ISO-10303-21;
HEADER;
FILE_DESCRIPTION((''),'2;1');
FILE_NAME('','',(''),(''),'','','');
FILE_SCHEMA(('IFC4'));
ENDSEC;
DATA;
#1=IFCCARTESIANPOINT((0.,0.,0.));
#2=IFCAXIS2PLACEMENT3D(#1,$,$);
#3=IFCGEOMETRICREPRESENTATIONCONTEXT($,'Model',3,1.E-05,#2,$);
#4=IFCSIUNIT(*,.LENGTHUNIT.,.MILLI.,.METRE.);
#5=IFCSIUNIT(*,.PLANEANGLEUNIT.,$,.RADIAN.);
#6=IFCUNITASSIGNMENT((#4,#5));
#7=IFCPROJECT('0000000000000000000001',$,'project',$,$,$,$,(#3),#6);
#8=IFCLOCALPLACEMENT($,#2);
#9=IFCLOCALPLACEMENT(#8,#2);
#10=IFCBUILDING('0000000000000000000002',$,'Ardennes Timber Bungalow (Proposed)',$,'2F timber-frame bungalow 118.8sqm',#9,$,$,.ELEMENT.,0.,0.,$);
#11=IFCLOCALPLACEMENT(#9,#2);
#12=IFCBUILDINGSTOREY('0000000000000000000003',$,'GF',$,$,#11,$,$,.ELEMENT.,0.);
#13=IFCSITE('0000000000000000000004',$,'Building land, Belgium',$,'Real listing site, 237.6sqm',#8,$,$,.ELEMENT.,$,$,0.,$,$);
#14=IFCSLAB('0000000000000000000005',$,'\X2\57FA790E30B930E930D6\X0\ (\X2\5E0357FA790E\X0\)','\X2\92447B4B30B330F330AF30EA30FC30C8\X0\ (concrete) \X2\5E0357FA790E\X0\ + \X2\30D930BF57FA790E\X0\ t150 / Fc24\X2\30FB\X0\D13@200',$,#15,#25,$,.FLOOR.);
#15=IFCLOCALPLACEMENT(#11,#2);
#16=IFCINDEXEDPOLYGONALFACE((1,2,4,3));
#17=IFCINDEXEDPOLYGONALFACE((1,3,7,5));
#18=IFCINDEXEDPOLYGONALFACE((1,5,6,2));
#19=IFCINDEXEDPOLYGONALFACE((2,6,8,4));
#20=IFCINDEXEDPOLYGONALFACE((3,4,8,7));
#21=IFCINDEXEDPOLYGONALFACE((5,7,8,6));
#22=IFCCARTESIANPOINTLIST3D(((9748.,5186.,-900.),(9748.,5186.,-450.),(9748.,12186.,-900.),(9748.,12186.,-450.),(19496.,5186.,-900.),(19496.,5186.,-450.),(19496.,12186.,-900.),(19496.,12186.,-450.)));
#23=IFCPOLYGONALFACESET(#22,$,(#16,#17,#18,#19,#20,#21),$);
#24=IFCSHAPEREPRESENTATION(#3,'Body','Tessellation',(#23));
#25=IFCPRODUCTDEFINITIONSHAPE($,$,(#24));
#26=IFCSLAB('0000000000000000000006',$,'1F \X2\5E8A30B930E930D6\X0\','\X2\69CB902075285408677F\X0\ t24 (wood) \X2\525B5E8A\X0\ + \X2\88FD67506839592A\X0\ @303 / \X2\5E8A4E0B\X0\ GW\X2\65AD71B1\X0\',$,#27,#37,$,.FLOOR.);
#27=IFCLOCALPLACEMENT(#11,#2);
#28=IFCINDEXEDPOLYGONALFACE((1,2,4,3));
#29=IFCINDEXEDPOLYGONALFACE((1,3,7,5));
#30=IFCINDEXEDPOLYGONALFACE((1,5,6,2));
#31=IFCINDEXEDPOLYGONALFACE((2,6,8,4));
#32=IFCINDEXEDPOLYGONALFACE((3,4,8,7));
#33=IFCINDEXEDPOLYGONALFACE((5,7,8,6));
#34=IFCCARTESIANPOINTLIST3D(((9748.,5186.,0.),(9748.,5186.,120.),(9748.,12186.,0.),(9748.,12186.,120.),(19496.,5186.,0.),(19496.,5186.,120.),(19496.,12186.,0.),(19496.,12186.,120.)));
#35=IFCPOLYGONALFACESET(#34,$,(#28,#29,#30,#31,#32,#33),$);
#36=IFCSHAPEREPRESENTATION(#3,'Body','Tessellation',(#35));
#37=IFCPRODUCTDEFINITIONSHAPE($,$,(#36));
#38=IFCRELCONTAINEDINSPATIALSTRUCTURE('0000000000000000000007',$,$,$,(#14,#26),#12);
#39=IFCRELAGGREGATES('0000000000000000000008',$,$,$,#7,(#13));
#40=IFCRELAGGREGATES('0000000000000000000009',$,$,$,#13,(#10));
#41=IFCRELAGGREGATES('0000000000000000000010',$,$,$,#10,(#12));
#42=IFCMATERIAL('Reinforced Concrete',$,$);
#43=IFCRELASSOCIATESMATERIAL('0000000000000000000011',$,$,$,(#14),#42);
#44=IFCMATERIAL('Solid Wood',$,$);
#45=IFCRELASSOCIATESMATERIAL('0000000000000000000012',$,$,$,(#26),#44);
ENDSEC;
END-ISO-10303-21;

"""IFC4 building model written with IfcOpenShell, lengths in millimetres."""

from ifc_helpers import new_model, si_unit, frame, frame_2d, origin, place, context, project, spatial, rectangle, extrude, material, element, save


model = new_model("IFC4")

# Units and contexts
model_context = context("Model", 3, precision=1e-05, world=origin())
ifc_project = project(units=[si_unit("LENGTHUNIT", "METRE", prefix="MILLI"), si_unit("PLANEANGLEUNIT", "RADIAN")], contexts=[model_context])

# Site, building, storey
site_placement = place(None, origin())
site = spatial("IfcSite", under=ifc_project, at=site_placement, Name="Building land, Belgium", ObjectType="Real listing site, 237.6sqm", CompositionType="ELEMENT", RefElevation=0.0)
building_placement = place(site_placement, origin())
building = spatial("IfcBuilding", under=site, at=building_placement, Name="Ardennes Timber Bungalow (Proposed)", ObjectType="2F timber-frame bungalow 118.8sqm", CompositionType="ELEMENT", ElevationOfRefHeight=0.0, ElevationOfTerrain=0.0)
storey_placement = place(building_placement, origin())
storey = spatial("IfcBuildingStorey", under=building, at=storey_placement, Name="GF", CompositionType="ELEMENT", Elevation=0.0)

# Slabs
ifc_material_1 = material(Name="Reinforced Concrete")
slab_1_placement = place(storey_placement, frame((4874.0, 2593.0, -450.0)))
element("IfcSlab", 1, at=slab_1_placement, inside=storey, material=ifc_material_1, Name="基礎スラブ (布基礎)", Description="鉄筋コンクリート (concrete) 布基礎 + ベタ基礎 t150 / Fc24・D13@200", PredefinedType="FLOOR", context=model_context, shape_type="SweptSolid", body=[
    extrude(rectangle(XDim=9748.0, YDim=7000.0, at=frame_2d((4874.0, 3500.0))), frame((4874.0, 2593.0, -450.0)), (0.0, 0.0, 1.0), 450.0),
])
ifc_material_2 = material(Name="Solid Wood")
slab_2_placement = place(storey_placement, frame((4874.0, 2593.0, 0.0)))
element("IfcSlab", 2, at=slab_2_placement, inside=storey, material=ifc_material_2, Name="1F 床スラブ", Description="構造用合板 t24 (wood) 剛床 + 製材根太 @303 / 床下 GW断熱", PredefinedType="FLOOR", context=model_context, shape_type="SweptSolid", body=[
    extrude(rectangle(XDim=9748.0, YDim=7000.0, at=frame_2d((4874.0, 3500.0))), frame((4874.0, 2593.0, 0.0)), (0.0, 0.0, 1.0), 120.0),
])

save(model, "model.ifc")
